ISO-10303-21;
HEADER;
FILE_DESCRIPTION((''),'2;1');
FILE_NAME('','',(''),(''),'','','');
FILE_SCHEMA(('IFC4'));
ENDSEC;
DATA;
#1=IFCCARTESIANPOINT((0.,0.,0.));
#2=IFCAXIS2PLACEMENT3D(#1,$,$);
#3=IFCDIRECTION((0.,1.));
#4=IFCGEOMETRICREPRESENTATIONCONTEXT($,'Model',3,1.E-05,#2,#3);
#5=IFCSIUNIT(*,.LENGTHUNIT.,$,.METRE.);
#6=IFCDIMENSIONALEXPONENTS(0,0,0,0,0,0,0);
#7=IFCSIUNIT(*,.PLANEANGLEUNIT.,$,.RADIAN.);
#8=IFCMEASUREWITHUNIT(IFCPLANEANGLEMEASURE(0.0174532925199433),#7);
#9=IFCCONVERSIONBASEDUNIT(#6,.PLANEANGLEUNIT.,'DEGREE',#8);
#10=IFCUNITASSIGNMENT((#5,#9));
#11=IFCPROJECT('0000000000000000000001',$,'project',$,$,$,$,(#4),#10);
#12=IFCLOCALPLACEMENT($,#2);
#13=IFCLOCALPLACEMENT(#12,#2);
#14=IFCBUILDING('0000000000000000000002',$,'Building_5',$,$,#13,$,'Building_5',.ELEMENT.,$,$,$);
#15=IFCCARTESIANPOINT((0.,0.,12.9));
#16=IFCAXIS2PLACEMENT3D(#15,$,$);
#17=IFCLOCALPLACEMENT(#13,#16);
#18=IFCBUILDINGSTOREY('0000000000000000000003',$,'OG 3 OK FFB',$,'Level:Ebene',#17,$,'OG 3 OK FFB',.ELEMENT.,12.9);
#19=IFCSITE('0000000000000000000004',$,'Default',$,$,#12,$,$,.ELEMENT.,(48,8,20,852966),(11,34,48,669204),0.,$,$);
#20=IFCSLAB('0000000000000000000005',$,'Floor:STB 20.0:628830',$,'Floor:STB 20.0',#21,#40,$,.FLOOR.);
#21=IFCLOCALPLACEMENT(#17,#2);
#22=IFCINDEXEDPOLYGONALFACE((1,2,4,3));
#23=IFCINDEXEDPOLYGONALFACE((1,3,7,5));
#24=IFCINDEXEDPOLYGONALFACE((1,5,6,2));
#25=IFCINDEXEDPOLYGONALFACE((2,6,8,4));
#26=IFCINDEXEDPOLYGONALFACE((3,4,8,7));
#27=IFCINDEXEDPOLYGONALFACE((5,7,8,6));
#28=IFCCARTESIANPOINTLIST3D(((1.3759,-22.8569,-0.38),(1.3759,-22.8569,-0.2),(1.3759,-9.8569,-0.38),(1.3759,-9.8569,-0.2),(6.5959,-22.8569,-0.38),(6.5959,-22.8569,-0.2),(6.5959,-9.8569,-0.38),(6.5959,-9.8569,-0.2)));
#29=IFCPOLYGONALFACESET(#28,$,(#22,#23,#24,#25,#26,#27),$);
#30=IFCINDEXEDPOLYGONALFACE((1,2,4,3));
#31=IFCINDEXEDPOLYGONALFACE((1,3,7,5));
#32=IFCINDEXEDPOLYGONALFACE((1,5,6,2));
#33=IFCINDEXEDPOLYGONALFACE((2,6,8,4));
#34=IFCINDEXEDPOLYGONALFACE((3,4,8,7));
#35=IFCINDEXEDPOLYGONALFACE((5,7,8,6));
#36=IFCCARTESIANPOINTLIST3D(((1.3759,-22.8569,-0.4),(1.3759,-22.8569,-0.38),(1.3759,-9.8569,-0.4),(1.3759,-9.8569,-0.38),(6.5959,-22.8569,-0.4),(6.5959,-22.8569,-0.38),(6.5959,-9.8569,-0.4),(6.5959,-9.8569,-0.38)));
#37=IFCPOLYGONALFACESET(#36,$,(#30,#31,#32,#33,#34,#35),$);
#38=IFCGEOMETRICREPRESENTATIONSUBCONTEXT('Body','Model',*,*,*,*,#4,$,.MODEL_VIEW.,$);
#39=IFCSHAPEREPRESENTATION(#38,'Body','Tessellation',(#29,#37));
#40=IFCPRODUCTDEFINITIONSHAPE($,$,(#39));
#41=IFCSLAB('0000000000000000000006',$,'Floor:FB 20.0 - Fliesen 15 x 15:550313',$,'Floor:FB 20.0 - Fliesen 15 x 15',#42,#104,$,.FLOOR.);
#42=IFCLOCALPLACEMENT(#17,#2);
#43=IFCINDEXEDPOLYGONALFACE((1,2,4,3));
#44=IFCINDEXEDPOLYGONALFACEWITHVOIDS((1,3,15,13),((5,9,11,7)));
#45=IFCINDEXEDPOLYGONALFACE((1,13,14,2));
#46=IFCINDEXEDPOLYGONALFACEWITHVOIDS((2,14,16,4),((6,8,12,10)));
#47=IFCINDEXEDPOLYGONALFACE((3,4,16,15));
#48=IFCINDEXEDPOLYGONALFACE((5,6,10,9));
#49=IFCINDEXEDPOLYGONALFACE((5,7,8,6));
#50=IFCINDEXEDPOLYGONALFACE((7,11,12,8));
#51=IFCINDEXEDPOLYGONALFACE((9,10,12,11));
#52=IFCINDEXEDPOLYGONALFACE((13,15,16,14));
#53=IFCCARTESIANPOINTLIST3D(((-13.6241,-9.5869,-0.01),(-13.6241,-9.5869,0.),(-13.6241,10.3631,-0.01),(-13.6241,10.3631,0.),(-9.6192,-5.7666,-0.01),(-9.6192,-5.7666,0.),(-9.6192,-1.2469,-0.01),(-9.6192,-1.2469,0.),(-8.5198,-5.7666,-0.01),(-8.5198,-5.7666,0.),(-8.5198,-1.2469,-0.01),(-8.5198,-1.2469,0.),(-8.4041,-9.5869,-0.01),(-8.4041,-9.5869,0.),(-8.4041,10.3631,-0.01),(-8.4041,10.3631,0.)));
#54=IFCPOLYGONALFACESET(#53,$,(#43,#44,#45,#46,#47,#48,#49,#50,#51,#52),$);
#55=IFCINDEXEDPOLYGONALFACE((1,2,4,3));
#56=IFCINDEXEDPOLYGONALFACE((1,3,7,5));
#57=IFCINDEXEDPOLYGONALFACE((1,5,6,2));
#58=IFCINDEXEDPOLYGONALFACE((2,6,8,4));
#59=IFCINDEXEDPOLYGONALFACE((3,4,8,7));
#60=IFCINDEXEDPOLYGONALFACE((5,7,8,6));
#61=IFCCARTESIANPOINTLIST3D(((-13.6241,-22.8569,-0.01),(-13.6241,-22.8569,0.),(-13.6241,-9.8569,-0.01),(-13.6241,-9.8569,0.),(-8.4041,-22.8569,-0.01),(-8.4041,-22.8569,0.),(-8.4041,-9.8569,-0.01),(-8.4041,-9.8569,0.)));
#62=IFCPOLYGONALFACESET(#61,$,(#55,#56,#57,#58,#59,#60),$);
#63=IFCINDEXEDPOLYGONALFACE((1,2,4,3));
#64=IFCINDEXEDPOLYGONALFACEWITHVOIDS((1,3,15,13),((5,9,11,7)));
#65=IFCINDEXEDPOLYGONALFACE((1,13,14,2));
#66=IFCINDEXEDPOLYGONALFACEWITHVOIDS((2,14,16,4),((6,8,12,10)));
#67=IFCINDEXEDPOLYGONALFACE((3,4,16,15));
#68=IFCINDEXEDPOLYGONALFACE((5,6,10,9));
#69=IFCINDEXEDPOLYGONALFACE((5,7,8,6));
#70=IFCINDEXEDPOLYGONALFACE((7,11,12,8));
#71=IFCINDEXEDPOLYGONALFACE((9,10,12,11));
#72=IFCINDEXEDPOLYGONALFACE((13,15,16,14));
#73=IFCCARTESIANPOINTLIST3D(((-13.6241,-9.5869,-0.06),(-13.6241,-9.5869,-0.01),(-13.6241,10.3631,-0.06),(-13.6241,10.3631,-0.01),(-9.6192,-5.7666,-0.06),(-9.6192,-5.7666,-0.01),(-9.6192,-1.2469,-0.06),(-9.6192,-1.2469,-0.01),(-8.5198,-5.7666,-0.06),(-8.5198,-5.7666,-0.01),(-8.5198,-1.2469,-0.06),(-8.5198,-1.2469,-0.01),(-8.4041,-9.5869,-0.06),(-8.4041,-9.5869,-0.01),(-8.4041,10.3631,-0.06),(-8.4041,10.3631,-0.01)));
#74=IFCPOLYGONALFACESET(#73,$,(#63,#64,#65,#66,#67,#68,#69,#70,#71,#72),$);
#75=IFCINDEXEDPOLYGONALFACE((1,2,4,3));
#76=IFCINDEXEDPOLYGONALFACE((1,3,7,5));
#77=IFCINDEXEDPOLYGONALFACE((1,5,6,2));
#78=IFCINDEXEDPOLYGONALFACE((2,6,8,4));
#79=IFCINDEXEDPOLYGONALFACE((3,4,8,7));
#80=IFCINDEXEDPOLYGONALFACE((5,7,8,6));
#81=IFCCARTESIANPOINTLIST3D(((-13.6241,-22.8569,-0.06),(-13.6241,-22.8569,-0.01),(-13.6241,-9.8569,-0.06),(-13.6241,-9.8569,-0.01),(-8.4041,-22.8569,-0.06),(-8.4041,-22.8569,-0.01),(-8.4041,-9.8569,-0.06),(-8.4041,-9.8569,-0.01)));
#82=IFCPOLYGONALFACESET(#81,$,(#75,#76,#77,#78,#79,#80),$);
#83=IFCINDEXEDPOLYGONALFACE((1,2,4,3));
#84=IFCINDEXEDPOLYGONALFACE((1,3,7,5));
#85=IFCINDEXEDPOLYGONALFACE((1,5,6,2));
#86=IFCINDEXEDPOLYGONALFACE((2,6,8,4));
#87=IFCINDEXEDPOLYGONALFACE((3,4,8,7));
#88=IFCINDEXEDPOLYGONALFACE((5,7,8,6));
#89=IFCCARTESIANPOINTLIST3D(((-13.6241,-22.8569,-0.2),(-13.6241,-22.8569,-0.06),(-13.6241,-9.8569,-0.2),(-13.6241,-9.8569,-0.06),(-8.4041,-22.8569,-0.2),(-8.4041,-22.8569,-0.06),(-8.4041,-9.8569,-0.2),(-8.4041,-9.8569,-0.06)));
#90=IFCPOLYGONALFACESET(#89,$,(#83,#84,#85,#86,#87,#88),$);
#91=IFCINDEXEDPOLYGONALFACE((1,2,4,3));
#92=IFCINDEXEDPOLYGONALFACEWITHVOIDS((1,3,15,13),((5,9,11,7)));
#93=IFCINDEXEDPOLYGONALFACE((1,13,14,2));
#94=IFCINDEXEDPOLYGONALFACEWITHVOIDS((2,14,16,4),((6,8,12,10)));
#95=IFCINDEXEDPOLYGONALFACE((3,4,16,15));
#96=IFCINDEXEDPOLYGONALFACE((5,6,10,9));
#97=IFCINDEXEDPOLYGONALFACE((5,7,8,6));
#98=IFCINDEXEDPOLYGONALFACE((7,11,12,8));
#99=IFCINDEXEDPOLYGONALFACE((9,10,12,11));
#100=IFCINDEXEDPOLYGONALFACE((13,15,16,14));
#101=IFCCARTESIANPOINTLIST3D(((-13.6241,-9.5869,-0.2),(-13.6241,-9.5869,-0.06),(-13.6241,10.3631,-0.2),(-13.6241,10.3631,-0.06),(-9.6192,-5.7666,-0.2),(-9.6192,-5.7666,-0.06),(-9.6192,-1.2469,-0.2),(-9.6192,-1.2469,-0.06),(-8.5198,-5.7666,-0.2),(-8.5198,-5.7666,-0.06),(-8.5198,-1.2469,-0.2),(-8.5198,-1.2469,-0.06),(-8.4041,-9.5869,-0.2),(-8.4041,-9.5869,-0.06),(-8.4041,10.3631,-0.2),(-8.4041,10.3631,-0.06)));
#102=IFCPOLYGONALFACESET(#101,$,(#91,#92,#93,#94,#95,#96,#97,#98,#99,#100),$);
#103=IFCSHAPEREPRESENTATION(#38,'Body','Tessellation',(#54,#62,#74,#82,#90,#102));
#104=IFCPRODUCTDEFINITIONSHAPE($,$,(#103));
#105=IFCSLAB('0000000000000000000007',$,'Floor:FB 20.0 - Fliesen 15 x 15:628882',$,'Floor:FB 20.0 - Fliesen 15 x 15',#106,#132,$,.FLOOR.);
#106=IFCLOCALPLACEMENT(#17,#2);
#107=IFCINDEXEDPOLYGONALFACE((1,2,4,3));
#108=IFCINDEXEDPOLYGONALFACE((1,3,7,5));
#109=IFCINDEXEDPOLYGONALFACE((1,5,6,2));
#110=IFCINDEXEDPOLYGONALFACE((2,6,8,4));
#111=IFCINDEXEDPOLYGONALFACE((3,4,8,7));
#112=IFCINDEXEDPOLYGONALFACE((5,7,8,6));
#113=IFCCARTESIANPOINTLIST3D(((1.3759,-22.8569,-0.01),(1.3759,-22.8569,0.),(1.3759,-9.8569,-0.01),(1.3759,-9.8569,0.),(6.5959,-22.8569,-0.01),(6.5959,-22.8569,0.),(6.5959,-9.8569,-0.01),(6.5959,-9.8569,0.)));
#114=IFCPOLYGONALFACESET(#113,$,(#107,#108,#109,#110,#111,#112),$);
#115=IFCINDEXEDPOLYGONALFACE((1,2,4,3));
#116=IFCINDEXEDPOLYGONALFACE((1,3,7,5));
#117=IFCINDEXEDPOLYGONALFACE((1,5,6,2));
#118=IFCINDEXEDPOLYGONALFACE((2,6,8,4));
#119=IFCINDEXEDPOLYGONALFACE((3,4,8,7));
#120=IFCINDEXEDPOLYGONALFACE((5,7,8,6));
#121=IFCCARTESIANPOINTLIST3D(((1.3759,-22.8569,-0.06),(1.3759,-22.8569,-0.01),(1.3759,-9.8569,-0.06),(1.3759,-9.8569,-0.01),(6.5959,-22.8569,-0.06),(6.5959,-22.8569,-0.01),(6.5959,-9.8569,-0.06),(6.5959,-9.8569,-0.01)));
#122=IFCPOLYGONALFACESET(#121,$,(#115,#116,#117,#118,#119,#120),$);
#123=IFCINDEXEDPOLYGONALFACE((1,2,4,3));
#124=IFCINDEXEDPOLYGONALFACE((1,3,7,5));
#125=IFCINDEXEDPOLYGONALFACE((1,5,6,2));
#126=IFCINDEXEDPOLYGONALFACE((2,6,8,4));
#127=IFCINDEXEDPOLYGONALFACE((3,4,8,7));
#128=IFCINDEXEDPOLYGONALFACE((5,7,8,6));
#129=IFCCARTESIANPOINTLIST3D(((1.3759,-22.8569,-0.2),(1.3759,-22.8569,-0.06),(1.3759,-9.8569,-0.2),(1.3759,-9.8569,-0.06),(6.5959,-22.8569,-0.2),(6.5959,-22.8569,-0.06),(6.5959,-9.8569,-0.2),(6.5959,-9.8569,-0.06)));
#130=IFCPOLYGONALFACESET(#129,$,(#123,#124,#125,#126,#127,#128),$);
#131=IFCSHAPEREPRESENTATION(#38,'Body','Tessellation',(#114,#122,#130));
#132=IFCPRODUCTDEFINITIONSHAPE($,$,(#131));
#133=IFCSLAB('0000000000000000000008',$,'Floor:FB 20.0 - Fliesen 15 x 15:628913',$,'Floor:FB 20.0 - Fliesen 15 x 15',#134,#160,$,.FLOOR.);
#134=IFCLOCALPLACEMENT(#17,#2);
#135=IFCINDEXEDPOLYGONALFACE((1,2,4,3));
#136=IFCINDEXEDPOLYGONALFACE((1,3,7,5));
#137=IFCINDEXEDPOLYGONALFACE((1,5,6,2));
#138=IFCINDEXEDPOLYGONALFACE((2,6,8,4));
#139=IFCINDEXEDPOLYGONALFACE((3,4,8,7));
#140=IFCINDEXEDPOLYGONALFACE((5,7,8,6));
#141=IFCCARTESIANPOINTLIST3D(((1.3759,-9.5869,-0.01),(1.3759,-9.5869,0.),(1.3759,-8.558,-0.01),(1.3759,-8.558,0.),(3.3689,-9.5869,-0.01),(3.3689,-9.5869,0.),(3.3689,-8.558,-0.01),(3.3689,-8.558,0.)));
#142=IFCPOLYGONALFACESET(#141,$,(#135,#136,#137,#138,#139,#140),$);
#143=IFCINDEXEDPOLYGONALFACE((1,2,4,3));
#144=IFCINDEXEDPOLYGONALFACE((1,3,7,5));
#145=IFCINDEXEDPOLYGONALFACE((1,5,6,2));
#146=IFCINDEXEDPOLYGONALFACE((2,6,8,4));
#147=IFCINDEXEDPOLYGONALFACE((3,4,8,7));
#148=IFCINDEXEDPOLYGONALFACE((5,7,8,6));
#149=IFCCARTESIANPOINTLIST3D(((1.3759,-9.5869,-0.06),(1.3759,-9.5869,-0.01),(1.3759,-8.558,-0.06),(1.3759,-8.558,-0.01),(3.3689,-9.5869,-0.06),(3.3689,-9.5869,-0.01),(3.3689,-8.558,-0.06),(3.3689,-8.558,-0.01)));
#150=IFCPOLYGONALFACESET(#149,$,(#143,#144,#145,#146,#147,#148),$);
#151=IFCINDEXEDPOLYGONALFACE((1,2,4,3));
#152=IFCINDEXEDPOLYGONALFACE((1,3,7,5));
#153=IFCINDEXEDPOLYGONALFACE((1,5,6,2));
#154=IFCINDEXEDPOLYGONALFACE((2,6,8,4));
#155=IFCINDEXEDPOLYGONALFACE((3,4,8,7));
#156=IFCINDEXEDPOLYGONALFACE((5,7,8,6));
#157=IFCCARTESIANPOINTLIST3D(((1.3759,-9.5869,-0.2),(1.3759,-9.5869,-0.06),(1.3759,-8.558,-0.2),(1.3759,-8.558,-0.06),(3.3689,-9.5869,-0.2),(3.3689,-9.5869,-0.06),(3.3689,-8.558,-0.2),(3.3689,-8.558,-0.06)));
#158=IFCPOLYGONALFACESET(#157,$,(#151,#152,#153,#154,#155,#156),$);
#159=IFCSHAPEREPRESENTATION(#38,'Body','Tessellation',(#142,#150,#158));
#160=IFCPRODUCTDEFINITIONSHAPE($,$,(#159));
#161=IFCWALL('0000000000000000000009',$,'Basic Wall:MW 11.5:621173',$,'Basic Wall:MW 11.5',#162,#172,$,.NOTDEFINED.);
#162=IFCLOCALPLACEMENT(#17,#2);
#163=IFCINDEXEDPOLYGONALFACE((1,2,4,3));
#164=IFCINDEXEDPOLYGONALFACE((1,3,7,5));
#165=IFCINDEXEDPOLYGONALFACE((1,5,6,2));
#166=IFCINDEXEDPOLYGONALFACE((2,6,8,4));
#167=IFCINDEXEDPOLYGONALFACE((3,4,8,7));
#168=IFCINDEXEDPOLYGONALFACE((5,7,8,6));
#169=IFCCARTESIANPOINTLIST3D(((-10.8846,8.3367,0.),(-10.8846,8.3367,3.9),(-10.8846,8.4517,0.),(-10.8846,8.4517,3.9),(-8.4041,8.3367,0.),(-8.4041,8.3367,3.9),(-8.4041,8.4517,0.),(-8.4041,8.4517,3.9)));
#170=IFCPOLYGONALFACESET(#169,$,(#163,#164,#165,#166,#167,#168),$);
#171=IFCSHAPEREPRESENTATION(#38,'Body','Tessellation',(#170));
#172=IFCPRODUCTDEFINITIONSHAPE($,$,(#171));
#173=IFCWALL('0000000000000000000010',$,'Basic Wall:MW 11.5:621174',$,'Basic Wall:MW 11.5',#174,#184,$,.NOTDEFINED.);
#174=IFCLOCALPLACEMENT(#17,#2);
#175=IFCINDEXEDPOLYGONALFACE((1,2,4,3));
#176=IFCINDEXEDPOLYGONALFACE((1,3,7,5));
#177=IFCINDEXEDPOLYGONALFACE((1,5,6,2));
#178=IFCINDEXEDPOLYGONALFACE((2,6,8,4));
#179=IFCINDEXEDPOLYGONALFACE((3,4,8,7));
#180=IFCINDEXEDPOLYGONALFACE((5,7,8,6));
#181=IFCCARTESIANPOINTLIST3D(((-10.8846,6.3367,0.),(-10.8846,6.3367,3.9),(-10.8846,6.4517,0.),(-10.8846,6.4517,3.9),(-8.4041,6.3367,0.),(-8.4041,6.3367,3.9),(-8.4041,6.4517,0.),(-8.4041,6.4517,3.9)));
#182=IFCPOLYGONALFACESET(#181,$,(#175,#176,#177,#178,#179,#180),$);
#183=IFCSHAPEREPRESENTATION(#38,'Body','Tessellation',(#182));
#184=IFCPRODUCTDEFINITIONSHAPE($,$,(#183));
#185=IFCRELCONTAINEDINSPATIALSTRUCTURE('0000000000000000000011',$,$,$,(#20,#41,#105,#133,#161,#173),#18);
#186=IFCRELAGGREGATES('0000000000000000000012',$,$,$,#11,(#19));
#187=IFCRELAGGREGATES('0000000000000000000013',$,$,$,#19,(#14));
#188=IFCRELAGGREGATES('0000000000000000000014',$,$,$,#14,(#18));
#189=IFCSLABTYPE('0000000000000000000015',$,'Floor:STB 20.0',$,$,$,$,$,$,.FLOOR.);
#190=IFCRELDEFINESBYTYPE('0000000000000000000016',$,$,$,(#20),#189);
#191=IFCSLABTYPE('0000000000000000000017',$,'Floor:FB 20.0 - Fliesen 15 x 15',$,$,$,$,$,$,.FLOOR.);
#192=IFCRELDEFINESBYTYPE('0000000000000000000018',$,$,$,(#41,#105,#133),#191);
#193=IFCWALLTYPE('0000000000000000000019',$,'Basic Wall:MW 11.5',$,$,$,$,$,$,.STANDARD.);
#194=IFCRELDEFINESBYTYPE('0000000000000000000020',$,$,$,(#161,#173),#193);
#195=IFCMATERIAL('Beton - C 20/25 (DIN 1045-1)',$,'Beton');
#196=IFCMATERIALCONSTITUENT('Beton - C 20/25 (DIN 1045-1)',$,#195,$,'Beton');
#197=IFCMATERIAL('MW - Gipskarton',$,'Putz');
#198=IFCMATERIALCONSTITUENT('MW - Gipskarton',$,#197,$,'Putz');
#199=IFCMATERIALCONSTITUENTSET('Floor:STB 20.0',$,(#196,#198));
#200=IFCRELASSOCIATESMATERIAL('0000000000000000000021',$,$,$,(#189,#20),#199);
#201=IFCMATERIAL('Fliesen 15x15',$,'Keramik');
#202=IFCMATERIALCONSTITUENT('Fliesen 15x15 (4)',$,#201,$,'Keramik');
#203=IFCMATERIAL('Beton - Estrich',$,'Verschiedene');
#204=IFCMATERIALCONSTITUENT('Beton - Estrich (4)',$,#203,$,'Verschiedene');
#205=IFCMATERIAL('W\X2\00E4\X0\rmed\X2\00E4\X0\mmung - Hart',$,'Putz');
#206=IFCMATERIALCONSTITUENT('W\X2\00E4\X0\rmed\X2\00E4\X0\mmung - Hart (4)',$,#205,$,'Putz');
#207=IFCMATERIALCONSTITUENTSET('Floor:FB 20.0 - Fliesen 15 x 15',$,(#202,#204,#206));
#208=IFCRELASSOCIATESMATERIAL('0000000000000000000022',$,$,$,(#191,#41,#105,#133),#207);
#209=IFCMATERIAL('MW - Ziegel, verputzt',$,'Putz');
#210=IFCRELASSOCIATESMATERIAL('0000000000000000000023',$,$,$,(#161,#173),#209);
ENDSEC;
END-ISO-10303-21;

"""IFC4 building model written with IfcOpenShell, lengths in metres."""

from ifc_helpers import new_model, entity, si_unit, converted_unit, direction, frame, origin, place, context, subcontext, project, spatial, indexed_curve, outline, extrude, material, constituent, constituent_set, type_object, element, save


model = new_model("IFC4")

# Units and contexts
model_context = context("Model", 3, precision=1e-05, world=origin(), true_north=direction((0.0, 1.0)))
body_context = subcontext(model_context, "Body", "Model", "MODEL_VIEW")
ifc_project = project(units=[si_unit("LENGTHUNIT", "METRE"), converted_unit("PLANEANGLEUNIT", "DEGREE", entity("IfcPlaneAngleMeasure", 0.0174532925199433), si_unit("PLANEANGLEUNIT", "RADIAN"), dimensions=[0, 0, 0, 0, 0, 0, 0])], contexts=[model_context])

# Site, building, storey
site_placement = place(None, origin())
site = spatial("IfcSite", under=ifc_project, at=site_placement, Name="Default", CompositionType="ELEMENT", RefLatitude=(48, 8, 20, 852966), RefLongitude=(11, 34, 48, 669204), RefElevation=0.0)
building_placement = place(site_placement, origin())
building = spatial("IfcBuilding", under=site, at=building_placement, Name="Building_5", LongName="Building_5", CompositionType="ELEMENT")
storey_placement = place(building_placement, frame((0.0, 0.0, 12.9)))
storey = spatial("IfcBuildingStorey", under=building, at=storey_placement, Name="OG 3 OK FFB", ObjectType="Level:Ebene", LongName="OG 3 OK FFB", CompositionType="ELEMENT", Elevation=12.9)

# Shared definitions
ifc_material_1 = material(Name="Beton - C 20/25 (DIN 1045-1)", Category="Beton")
ifc_constituent_1 = constituent(ifc_material_1, Name="Beton - C 20/25 (DIN 1045-1)", Category="Beton")
ifc_material_2 = material(Name="MW - Gipskarton", Category="Putz")
ifc_constituent_2 = constituent(ifc_material_2, Name="MW - Gipskarton", Category="Putz")
ifc_constituent_set_1 = constituent_set(constituents=[ifc_constituent_1, ifc_constituent_2], Name="Floor:STB 20.0")
slab_type_1 = type_object("IfcSlabType", Name="Floor:STB 20.0", PredefinedType="FLOOR", material=ifc_constituent_set_1)

# Slab
slab_1_placement = place(storey_placement, origin())
element("IfcSlab", 1, at=slab_1_placement, inside=storey, type_object=slab_type_1, material=ifc_constituent_set_1, Name="Floor:STB 20.0:628830", ObjectType="Floor:STB 20.0", PredefinedType="FLOOR", context=body_context, shape_type="SweptSolid", body=[
    extrude(outline(indexed_curve([(-2.61, -6.5), (2.61, -6.5), (2.61, 6.5), (-2.61, 6.5), (-2.61, -6.5)], self_intersect=False)), frame((3.9859, -16.3569, -0.38), z_axis=(0.0, 0.0, 1.0), x_axis=(-1.0, 0.0, 0.0)), (0.0, 0.0, 1.0), 0.18),
    extrude(outline(indexed_curve([(-2.61, -6.5), (2.61, -6.5), (2.61, 6.5), (-2.61, 6.5), (-2.61, -6.5)], self_intersect=False)), frame((3.9859, -16.3569, -0.4), z_axis=(0.0, 0.0, 1.0), x_axis=(-1.0, 0.0, 0.0)), (0.0, 0.0, 1.0), 0.02),
])

# Slab, opening
ifc_material_3 = material(Name="Fliesen 15x15", Category="Keramik")
ifc_constituent_3 = constituent(ifc_material_3, Name="Fliesen 15x15 (4)", Category="Keramik")
ifc_material_4 = material(Name="Beton - Estrich", Category="Verschiedene")
ifc_constituent_4 = constituent(ifc_material_4, Name="Beton - Estrich (4)", Category="Verschiedene")
ifc_material_5 = material(Name="Wärmedämmung - Hart", Category="Putz")
ifc_constituent_5 = constituent(ifc_material_5, Name="Wärmedämmung - Hart (4)", Category="Putz")
ifc_constituent_set_2 = constituent_set(constituents=[ifc_constituent_3, ifc_constituent_4, ifc_constituent_5], Name="Floor:FB 20.0 - Fliesen 15 x 15")
slab_type_2 = type_object("IfcSlabType", Name="Floor:FB 20.0 - Fliesen 15 x 15", PredefinedType="FLOOR", material=ifc_constituent_set_2)
slab_2_placement = place(storey_placement, origin())
slab_2 = element("IfcSlab", 2, at=slab_2_placement, inside=storey, type_object=slab_type_2, material=ifc_constituent_set_2, Name="Floor:FB 20.0 - Fliesen 15 x 15:550313", ObjectType="Floor:FB 20.0 - Fliesen 15 x 15", PredefinedType="FLOOR", context=body_context, shape_type="SweptSolid", body=[
    extrude(outline(indexed_curve([(-2.61, -9.975), (2.61, -9.975), (2.61, 9.975), (-2.61, 9.975), (-2.61, -9.975)], self_intersect=False), holes=[indexed_curve([(-2.4943, 6.1547), (-1.3948, 6.1547), (-1.3948, 1.635), (-2.4943, 1.635), (-2.4943, 6.1547)], self_intersect=False)]), frame((-11.0141, 0.3881, -0.01), z_axis=(0.0, 0.0, 1.0), x_axis=(-1.0, 0.0, 0.0)), (0.0, 0.0, 1.0), 0.01),
    extrude(outline(indexed_curve([(-2.61, -6.5), (2.61, -6.5), (2.61, 6.5), (-2.61, 6.5), (-2.61, -6.5)], self_intersect=False)), frame((-11.0141, -16.3569, -0.01), z_axis=(0.0, 0.0, 1.0), x_axis=(-1.0, 0.0, 0.0)), (0.0, 0.0, 1.0), 0.01),
    extrude(outline(indexed_curve([(-2.61, -9.975), (2.61, -9.975), (2.61, 9.975), (-2.61, 9.975), (-2.61, -9.975)], self_intersect=False), holes=[indexed_curve([(-2.4943, 6.1547), (-1.3948, 6.1547), (-1.3948, 1.635), (-2.4943, 1.635), (-2.4943, 6.1547)], self_intersect=False)]), frame((-11.0141, 0.3881, -0.06), z_axis=(0.0, 0.0, 1.0), x_axis=(-1.0, 0.0, 0.0)), (0.0, 0.0, 1.0), 0.05),
    extrude(outline(indexed_curve([(-2.61, -6.5), (2.61, -6.5), (2.61, 6.5), (-2.61, 6.5), (-2.61, -6.5)], self_intersect=False)), frame((-11.0141, -16.3569, -0.06), z_axis=(0.0, 0.0, 1.0), x_axis=(-1.0, 0.0, 0.0)), (0.0, 0.0, 1.0), 0.05),
    extrude(outline(indexed_curve([(-2.61, -6.5), (2.61, -6.5), (2.61, 6.5), (-2.61, 6.5), (-2.61, -6.5)], self_intersect=False)), frame((-11.0141, -16.3569, -0.2), z_axis=(0.0, 0.0, 1.0), x_axis=(-1.0, 0.0, 0.0)), (0.0, 0.0, 1.0), 0.14),
    extrude(outline(indexed_curve([(-2.61, -9.975), (2.61, -9.975), (2.61, 9.975), (-2.61, 9.975), (-2.61, -9.975)], self_intersect=False), holes=[indexed_curve([(-2.4943, 6.1547), (-1.3948, 6.1547), (-1.3948, 1.635), (-2.4943, 1.635), (-2.4943, 6.1547)], self_intersect=False)]), frame((-11.0141, 0.3881, -0.2), z_axis=(0.0, 0.0, 1.0), x_axis=(-1.0, 0.0, 0.0)), (0.0, 0.0, 1.0), 0.14),
])
opening_1_placement = place(slab_2_placement, origin())
element("IfcOpeningElement", 3, at=opening_1_placement, cuts=slab_2, PredefinedType="OPENING", context=body_context, shape_type="SweptSolid", body=[
    extrude(outline(indexed_curve([(-0.5497, -2.2599), (0.5497, -2.2599), (0.5497, 2.2599), (-0.5497, 2.2599), (-0.5497, -2.2599)], self_intersect=False)), frame((-9.0695, -3.5067, 0.0), z_axis=(0.0, 0.0, -1.0), x_axis=(-1.0, 0.0, 0.0)), (0.0, 0.0, 1.0), 0.2),
])

# Slabs
slab_3_placement = place(storey_placement, origin())
element("IfcSlab", 4, at=slab_3_placement, inside=storey, type_object=slab_type_2, material=ifc_constituent_set_2, Name="Floor:FB 20.0 - Fliesen 15 x 15:628882", ObjectType="Floor:FB 20.0 - Fliesen 15 x 15", PredefinedType="FLOOR", context=body_context, shape_type="SweptSolid", body=[
    extrude(outline(indexed_curve([(-2.61, -6.5), (2.61, -6.5), (2.61, 6.5), (-2.61, 6.5), (-2.61, -6.5)], self_intersect=False)), frame((3.9859, -16.3569, -0.01), z_axis=(0.0, 0.0, 1.0), x_axis=(-1.0, 0.0, 0.0)), (0.0, 0.0, 1.0), 0.01),
    extrude(outline(indexed_curve([(-2.61, -6.5), (2.61, -6.5), (2.61, 6.5), (-2.61, 6.5), (-2.61, -6.5)], self_intersect=False)), frame((3.9859, -16.3569, -0.06), z_axis=(0.0, 0.0, 1.0), x_axis=(-1.0, 0.0, 0.0)), (0.0, 0.0, 1.0), 0.05),
    extrude(outline(indexed_curve([(-2.61, -6.5), (2.61, -6.5), (2.61, 6.5), (-2.61, 6.5), (-2.61, -6.5)], self_intersect=False)), frame((3.9859, -16.3569, -0.2), z_axis=(0.0, 0.0, 1.0), x_axis=(-1.0, 0.0, 0.0)), (0.0, 0.0, 1.0), 0.14),
])
slab_4_placement = place(storey_placement, origin())
element("IfcSlab", 5, at=slab_4_placement, inside=storey, type_object=slab_type_2, material=ifc_constituent_set_2, Name="Floor:FB 20.0 - Fliesen 15 x 15:628913", ObjectType="Floor:FB 20.0 - Fliesen 15 x 15", PredefinedType="FLOOR", context=body_context, shape_type="SweptSolid", body=[
    extrude(outline(indexed_curve([(-0.5144, -0.9965), (0.5144, -0.9965), (0.5144, 0.9965), (-0.5144, 0.9965), (-0.5144, -0.9965)], self_intersect=False)), frame((2.3724, -9.0724, -0.01), z_axis=(0.0, 0.0, 1.0), x_axis=(0.0, 1.0, 0.0)), (0.0, 0.0, 1.0), 0.01),
    extrude(outline(indexed_curve([(-0.5144, -0.9965), (0.5144, -0.9965), (0.5144, 0.9965), (-0.5144, 0.9965), (-0.5144, -0.9965)], self_intersect=False)), frame((2.3724, -9.0724, -0.06), z_axis=(0.0, 0.0, 1.0), x_axis=(0.0, 1.0, 0.0)), (0.0, 0.0, 1.0), 0.05),
    extrude(outline(indexed_curve([(-0.5144, -0.9965), (0.5144, -0.9965), (0.5144, 0.9965), (-0.5144, 0.9965), (-0.5144, -0.9965)], self_intersect=False)), frame((2.3724, -9.0724, -0.2), z_axis=(0.0, 0.0, 1.0), x_axis=(0.0, 1.0, 0.0)), (0.0, 0.0, 1.0), 0.14),
])

# Walls
ifc_material_6 = material(Name="MW - Ziegel, verputzt", Category="Putz")
wall_type_1 = type_object("IfcWallType", Name="Basic Wall:MW 11.5", PredefinedType="STANDARD")
for number, where, z_axis, x_axis, name in (
    (6, (-8.4041, 8.3942, 0.0), (0.0, 0.0, 1.0), (-1.0, 0.0, 0.0), "Basic Wall:MW 11.5:621173"),
    (7, (-8.4041, 6.3942, 0.0), (0.0, 0.0, 1.0), (-1.0, 0.0, 0.0), "Basic Wall:MW 11.5:621174"),
):
    element("IfcWall", number, at=place(storey_placement, frame(where, z_axis=z_axis, x_axis=x_axis)), inside=storey, type_object=wall_type_1, material=ifc_material_6, Name=name, ObjectType="Basic Wall:MW 11.5", PredefinedType="NOTDEFINED", context=body_context, shape_type="SweptSolid", body=[
        extrude(outline(indexed_curve([(2.4805, 0.0575), (0.0, 0.0575), (0.0, -0.0575), (2.4805, -0.0575), (2.4805, 0.0575)], self_intersect=False)), origin(), (0.0, 0.0, 1.0), 3.9),
    ])

save(model, "model.ifc")
